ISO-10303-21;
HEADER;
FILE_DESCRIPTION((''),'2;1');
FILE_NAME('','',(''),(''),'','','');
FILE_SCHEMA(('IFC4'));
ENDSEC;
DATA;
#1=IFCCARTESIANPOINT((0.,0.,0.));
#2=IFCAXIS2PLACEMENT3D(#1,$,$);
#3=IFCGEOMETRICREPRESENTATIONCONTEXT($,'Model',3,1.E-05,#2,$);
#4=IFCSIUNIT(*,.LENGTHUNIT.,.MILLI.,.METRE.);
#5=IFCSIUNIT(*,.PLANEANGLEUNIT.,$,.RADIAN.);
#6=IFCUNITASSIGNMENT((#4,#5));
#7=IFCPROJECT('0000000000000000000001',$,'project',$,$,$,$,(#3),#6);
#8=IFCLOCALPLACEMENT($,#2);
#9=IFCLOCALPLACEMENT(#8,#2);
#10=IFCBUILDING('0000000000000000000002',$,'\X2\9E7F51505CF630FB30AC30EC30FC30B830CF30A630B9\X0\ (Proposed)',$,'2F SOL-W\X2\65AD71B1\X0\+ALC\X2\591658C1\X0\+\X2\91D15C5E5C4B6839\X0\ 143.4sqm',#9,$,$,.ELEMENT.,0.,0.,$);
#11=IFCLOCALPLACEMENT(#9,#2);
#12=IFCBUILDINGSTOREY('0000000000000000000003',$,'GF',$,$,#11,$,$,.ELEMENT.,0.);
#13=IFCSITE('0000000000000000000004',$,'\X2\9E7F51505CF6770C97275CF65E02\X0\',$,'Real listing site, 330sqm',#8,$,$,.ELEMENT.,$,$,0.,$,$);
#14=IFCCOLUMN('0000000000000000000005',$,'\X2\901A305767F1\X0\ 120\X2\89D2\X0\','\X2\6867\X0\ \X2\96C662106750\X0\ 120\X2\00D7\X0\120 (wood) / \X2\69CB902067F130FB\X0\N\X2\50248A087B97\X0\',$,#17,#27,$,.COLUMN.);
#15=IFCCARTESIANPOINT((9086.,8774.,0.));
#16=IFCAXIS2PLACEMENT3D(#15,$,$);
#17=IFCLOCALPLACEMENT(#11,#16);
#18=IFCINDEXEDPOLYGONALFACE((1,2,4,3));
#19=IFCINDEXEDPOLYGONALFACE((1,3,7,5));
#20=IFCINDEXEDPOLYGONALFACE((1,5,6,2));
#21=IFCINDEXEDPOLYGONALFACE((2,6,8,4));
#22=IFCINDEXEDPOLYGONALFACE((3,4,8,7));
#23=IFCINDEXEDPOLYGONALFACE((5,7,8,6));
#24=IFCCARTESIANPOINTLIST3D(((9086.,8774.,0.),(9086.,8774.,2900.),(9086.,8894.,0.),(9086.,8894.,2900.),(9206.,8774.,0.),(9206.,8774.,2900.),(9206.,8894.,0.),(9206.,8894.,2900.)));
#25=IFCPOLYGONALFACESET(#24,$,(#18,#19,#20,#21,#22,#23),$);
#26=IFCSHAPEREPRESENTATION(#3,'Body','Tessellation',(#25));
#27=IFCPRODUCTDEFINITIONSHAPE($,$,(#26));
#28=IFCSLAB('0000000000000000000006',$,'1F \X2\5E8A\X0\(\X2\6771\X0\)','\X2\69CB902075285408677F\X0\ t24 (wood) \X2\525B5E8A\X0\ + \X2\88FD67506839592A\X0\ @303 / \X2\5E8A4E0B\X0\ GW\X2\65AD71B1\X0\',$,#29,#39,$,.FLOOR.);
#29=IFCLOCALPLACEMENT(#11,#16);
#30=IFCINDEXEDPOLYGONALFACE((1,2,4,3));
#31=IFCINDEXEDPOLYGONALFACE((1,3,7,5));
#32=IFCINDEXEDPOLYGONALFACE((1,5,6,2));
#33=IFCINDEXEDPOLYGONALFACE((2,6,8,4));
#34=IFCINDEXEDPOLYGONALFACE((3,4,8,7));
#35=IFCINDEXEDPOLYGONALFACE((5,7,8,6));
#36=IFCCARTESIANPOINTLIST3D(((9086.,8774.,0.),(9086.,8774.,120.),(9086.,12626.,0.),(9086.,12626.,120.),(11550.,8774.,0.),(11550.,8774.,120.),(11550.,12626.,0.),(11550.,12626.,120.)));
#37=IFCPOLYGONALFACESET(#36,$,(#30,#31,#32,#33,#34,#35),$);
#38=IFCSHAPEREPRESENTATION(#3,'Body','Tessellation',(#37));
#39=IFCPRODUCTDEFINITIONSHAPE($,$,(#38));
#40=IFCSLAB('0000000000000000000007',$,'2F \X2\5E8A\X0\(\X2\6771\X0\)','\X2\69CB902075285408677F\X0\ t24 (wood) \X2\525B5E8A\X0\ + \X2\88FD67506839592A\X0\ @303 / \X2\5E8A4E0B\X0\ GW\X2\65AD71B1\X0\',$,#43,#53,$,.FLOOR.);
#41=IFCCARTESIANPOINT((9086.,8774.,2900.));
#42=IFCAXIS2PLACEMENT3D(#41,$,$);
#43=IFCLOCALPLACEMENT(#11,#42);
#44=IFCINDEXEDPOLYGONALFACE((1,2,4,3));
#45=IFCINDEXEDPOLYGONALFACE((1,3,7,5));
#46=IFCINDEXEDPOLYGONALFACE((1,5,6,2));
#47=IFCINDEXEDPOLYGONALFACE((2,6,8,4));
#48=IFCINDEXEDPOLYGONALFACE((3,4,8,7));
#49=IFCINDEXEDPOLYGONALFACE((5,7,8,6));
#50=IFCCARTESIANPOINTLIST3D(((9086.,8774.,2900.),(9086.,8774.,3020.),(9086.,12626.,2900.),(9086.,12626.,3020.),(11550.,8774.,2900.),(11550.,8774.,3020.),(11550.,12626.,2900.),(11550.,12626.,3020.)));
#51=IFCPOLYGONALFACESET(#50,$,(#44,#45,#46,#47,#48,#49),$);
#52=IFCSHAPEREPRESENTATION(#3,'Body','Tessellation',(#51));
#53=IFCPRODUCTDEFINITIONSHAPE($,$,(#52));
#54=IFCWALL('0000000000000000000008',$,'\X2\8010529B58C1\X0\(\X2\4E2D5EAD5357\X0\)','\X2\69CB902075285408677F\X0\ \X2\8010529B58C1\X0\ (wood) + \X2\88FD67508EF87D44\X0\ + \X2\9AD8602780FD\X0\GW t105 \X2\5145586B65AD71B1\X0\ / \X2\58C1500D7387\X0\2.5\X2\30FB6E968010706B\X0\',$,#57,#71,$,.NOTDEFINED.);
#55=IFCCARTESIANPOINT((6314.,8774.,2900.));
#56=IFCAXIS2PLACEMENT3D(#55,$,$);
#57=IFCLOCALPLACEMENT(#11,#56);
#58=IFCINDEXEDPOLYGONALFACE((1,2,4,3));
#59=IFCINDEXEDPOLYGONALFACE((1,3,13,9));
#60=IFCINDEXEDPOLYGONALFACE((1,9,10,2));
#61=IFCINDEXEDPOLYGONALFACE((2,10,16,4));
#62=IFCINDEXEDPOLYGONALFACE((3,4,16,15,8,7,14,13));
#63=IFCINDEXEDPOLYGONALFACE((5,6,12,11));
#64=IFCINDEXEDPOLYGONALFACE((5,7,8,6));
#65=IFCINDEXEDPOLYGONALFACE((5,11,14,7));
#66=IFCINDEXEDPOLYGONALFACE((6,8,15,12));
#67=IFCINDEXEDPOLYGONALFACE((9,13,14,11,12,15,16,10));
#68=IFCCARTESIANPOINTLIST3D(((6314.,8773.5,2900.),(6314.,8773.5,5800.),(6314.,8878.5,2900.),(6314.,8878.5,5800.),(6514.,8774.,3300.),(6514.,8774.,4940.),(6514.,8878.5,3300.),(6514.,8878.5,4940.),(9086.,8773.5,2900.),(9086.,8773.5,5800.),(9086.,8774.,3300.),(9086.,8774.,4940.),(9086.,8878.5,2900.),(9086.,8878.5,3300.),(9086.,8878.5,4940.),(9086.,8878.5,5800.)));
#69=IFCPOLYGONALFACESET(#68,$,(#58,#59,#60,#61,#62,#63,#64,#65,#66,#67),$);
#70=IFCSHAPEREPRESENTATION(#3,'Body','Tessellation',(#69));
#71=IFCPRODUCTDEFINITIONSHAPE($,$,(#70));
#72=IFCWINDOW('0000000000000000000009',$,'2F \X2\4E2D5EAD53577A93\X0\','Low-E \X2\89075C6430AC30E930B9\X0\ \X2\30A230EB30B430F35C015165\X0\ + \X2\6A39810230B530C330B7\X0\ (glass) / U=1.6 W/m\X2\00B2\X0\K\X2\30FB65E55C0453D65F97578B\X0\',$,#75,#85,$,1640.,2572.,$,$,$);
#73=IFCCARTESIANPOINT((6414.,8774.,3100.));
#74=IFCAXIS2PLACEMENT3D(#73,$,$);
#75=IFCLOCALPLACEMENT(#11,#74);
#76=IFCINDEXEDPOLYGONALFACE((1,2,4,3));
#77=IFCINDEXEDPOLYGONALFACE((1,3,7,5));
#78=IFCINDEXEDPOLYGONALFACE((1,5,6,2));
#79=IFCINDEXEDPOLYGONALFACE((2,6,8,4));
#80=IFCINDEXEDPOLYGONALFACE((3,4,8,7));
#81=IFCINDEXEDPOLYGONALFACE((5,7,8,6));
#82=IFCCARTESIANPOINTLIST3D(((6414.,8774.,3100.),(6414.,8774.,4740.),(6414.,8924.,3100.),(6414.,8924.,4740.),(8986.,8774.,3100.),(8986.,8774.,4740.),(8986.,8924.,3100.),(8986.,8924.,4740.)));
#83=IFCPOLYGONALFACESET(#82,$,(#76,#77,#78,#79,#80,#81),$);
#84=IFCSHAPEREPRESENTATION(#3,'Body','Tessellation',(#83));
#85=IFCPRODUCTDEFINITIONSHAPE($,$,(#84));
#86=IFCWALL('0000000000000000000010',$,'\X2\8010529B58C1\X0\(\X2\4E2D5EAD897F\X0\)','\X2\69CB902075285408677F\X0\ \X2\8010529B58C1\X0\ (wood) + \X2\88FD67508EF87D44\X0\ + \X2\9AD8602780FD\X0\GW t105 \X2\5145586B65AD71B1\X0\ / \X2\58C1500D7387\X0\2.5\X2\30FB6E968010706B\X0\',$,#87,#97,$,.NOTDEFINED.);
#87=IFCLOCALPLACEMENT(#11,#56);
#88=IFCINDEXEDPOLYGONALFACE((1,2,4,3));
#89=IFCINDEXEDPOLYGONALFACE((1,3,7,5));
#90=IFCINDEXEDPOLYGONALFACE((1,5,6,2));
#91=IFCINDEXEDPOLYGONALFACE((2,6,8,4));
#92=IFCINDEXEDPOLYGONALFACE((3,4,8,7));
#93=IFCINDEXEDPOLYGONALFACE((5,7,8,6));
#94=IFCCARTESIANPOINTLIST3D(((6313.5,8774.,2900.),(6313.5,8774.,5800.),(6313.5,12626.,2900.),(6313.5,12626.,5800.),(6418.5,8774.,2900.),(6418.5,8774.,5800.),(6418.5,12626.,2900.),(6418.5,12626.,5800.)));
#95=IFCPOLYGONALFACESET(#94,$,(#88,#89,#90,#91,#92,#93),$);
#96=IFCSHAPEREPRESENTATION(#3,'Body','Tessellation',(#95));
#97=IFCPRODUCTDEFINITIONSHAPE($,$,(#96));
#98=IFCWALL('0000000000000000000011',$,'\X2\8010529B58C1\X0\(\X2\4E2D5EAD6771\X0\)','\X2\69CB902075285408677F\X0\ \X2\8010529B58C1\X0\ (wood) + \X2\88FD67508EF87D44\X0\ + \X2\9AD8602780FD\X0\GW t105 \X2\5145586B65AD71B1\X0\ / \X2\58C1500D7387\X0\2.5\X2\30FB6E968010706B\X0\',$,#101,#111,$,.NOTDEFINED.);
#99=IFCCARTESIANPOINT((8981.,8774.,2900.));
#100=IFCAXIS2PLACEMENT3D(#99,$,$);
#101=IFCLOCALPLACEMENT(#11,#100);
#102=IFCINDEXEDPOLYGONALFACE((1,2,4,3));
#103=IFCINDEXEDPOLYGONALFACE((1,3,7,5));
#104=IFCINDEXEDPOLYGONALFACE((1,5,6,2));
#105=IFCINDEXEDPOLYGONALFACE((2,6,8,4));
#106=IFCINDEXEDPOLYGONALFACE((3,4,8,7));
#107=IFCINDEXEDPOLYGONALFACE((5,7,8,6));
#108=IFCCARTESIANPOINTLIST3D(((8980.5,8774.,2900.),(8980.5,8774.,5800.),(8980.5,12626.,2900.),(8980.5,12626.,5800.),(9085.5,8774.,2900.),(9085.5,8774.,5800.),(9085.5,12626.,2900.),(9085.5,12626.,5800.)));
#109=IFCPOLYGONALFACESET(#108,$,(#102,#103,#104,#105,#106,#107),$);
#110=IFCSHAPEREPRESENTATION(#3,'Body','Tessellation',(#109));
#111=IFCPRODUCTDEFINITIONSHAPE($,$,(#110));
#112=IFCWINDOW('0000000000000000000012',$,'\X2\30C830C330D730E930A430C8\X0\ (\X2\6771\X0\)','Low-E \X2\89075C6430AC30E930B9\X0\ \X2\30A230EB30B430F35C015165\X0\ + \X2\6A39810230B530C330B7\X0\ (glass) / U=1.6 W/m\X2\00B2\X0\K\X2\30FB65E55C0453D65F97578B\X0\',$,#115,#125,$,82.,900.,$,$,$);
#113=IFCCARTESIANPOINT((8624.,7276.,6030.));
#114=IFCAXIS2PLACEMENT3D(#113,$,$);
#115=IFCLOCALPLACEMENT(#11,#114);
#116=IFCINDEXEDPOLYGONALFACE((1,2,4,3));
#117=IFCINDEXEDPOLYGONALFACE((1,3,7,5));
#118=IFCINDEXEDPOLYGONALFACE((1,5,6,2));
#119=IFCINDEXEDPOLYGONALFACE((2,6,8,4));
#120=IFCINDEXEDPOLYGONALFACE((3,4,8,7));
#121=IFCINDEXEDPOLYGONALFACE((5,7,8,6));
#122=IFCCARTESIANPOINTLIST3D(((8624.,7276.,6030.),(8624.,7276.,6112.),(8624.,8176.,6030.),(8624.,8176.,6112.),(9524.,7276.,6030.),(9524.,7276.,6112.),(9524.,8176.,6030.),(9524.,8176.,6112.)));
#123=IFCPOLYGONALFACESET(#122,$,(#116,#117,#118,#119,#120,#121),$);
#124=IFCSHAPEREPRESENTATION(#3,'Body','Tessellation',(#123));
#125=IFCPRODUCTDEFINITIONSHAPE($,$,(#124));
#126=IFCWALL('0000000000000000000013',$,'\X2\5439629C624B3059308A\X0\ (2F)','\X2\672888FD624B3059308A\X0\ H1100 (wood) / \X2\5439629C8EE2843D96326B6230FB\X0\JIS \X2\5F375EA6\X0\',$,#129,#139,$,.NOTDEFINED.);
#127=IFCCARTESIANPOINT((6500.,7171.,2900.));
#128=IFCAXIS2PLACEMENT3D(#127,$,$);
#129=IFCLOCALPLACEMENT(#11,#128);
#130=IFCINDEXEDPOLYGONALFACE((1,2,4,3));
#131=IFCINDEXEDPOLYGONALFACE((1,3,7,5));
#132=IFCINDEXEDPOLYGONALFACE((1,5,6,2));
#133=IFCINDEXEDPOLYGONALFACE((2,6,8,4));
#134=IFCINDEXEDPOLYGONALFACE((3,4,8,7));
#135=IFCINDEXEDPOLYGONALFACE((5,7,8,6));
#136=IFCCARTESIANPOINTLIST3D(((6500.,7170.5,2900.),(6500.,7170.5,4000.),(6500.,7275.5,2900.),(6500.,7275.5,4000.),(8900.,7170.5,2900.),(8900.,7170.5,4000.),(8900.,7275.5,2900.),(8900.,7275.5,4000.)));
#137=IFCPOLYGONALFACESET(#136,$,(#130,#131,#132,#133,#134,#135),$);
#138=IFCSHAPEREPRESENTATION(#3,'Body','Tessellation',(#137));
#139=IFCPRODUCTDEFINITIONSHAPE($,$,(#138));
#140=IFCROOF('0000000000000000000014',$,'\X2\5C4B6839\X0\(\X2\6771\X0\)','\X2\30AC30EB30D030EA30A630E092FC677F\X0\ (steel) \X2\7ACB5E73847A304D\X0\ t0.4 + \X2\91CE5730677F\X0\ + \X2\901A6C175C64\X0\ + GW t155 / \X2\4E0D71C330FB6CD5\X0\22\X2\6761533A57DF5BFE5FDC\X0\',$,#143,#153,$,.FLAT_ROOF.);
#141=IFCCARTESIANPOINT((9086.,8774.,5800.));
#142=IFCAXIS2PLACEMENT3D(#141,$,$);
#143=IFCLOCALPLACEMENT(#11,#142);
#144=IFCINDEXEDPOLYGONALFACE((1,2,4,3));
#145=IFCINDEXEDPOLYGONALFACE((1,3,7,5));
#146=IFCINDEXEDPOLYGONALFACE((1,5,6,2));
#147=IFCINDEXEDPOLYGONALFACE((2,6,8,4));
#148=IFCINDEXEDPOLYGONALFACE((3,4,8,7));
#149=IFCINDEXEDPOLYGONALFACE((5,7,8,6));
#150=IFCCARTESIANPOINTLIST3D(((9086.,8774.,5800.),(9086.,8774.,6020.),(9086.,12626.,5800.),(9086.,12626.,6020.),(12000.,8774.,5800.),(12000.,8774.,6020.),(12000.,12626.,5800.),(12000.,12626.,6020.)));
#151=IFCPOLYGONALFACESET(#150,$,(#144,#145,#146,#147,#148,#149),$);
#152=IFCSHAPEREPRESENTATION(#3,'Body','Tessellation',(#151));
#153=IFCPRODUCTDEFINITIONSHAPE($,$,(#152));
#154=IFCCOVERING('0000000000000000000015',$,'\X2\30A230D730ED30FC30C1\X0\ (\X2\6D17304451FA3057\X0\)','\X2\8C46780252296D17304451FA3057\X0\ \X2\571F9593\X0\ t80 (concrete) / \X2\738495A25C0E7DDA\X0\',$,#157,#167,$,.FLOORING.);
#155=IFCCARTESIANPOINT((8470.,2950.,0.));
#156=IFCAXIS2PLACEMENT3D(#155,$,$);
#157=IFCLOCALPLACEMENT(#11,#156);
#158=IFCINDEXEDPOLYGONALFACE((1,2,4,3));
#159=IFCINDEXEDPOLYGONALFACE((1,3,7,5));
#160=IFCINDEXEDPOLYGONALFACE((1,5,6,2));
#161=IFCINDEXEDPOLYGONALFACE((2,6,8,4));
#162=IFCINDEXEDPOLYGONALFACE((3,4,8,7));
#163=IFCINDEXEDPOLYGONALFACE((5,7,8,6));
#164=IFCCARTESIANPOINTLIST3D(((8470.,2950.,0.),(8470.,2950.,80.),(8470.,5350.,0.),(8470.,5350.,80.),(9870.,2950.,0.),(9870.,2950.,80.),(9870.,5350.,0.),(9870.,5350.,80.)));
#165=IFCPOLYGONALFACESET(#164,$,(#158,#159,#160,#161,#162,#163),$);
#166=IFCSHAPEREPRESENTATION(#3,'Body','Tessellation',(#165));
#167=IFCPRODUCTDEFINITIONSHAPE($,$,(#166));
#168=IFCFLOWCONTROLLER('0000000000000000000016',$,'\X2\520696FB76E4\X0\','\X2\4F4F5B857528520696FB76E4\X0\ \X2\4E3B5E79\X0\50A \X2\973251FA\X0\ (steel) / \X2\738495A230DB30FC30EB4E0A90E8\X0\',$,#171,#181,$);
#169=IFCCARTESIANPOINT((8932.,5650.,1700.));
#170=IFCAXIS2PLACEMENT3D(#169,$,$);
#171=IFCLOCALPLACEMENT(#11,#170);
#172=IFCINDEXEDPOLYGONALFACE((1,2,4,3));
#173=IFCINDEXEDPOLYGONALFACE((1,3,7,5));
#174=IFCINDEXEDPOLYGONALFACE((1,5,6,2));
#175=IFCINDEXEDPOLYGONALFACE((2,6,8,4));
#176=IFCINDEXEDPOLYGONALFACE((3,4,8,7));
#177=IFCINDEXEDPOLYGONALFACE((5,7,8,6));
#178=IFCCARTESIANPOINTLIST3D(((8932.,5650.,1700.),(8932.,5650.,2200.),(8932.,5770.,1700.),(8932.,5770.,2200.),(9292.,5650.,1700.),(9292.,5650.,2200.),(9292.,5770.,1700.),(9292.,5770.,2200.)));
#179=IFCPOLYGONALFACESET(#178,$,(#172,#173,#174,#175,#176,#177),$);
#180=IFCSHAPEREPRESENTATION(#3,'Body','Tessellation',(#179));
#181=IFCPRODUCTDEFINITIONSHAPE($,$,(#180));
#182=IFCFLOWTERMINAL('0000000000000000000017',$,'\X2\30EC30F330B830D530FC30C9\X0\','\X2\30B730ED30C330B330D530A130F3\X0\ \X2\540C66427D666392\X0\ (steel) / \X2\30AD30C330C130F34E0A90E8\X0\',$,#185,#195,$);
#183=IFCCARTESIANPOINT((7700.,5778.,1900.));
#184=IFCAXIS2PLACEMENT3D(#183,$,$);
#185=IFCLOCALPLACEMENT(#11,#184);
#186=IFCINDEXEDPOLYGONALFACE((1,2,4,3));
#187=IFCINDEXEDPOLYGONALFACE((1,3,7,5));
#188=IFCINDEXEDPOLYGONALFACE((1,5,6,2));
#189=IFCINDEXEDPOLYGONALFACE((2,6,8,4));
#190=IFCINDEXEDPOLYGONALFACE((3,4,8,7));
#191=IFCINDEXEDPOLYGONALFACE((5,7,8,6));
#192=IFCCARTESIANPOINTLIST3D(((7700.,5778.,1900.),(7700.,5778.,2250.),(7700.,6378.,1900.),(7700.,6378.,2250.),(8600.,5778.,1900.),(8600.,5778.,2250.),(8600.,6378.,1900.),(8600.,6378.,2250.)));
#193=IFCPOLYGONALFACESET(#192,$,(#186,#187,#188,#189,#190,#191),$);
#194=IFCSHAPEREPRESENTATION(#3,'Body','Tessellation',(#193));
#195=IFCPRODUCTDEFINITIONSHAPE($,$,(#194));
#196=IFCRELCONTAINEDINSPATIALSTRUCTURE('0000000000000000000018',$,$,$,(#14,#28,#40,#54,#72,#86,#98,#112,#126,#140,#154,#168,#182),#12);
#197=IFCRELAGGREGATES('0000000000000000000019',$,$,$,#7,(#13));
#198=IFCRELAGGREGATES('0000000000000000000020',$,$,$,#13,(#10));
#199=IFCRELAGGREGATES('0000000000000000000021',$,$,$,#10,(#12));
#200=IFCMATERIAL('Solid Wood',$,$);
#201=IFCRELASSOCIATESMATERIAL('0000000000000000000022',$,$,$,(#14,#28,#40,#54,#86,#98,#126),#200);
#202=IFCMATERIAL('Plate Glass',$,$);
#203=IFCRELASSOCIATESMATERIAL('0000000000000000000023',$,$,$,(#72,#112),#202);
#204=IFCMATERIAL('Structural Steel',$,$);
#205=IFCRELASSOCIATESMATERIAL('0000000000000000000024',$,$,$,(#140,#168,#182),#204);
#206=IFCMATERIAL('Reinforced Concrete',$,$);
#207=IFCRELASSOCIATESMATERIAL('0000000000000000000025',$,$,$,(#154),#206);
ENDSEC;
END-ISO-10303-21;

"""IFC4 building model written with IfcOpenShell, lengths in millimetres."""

from ifc_helpers import new_model, si_unit, frame, frame_2d, origin, place, context, project, spatial, rectangle, extrude, material, element, fill, save


model = new_model("IFC4")

# Units and contexts
model_context = context("Model", 3, precision=1e-05, world=origin())
ifc_project = project(units=[si_unit("LENGTHUNIT", "METRE", prefix="MILLI"), si_unit("PLANEANGLEUNIT", "RADIAN")], contexts=[model_context])

# Site, building, storey
site_placement = place(None, origin())
site = spatial("IfcSite", under=ifc_project, at=site_placement, Name="鹿児島県霧島市", ObjectType="Real listing site, 330sqm", CompositionType="ELEMENT", RefElevation=0.0)
building_placement = place(site_placement, origin())
building = spatial("IfcBuilding", under=site, at=building_placement, Name="鹿児島・ガレージハウス (Proposed)", ObjectType="2F SOL-W断熱+ALC外壁+金属屋根 143.4sqm", CompositionType="ELEMENT", ElevationOfRefHeight=0.0, ElevationOfTerrain=0.0)
storey_placement = place(building_placement, origin())
storey = spatial("IfcBuildingStorey", under=building, at=storey_placement, Name="GF", CompositionType="ELEMENT", Elevation=0.0)

# Column
ifc_material_1 = material(Name="Solid Wood")
column_1_placement = place(storey_placement, frame((9086.0, 8774.0, 0.0)))
element("IfcColumn", 1, at=column_1_placement, inside=storey, material=ifc_material_1, Name="通し柱 120角", Description="桧 集成材 120×120 (wood) / 構造柱・N値計算", PredefinedType="COLUMN", context=model_context, shape_type="SweptSolid", body=[
    extrude(rectangle(XDim=120.0, YDim=120.0, at=frame_2d((60.0, 60.0))), frame((9086.0, 8774.0, 0.0)), (0.0, 0.0, 1.0), 2900.0),
])

# Slabs
slab_1_placement = place(storey_placement, frame((9086.0, 8774.0, 0.0)))
element("IfcSlab", 2, at=slab_1_placement, inside=storey, material=ifc_material_1, Name="1F 床(東)", Description="構造用合板 t24 (wood) 剛床 + 製材根太 @303 / 床下 GW断熱", PredefinedType="FLOOR", context=model_context, shape_type="SweptSolid", body=[
    extrude(rectangle(XDim=2464.0, YDim=3852.0, at=frame_2d((1232.0, 1926.0))), frame((9086.0, 8774.0, 0.0)), (0.0, 0.0, 1.0), 120.0),
])
slab_2_placement = place(storey_placement, frame((9086.0, 8774.0, 2900.0)))
element("IfcSlab", 3, at=slab_2_placement, inside=storey, material=ifc_material_1, Name="2F 床(東)", Description="構造用合板 t24 (wood) 剛床 + 製材根太 @303 / 床下 GW断熱", PredefinedType="FLOOR", context=model_context, shape_type="SweptSolid", body=[
    extrude(rectangle(XDim=2464.0, YDim=3852.0, at=frame_2d((1232.0, 1926.0))), frame((9086.0, 8774.0, 2900.0)), (0.0, 0.0, 1.0), 120.0),
])

# Wall, opening, window
wall_1_placement = place(storey_placement, frame((6314.0, 8774.0, 2900.0)))
wall_1 = element("IfcWall", 4, at=wall_1_placement, inside=storey, material=ifc_material_1, Name="耐力壁(中庭南)", Description="構造用合板 耐力壁 (wood) + 製材軸組 + 高性能GW t105 充填断熱 / 壁倍率2.5・準耐火", PredefinedType="NOTDEFINED", context=model_context, shape_type="SweptSolid", body=[
    extrude(rectangle(XDim=2772.0, YDim=105.0, at=frame_2d((1386.0, 52.0))), frame((6314.0, 8774.0, 2900.0)), (0.0, 0.0, 1.0), 2900.0),
])
opening_placement = place(storey_placement, frame((6414.0, 8774.0, 3100.0)))
opening = element("IfcOpeningElement", 5, at=opening_placement, cuts=wall_1, PredefinedType="NOTDEFINED", context=model_context, shape_type="SweptSolid", body=[
    extrude(rectangle(XDim=2572.0, YDim=150.0, at=frame_2d((1286.0, 75.0))), frame((6414.0, 8774.0, 3100.0)), (0.0, 0.0, 1.0), 1640.0),
])
ifc_material_2 = material(Name="Plate Glass")
window_1_placement = place(storey_placement, frame((6414.0, 8774.0, 3100.0)))
window_1 = element("IfcWindow", 6, at=window_1_placement, inside=storey, material=ifc_material_2, Name="2F 中庭南窓", Description="Low-E 複層ガラス アルゴン封入 + 樹脂サッシ (glass) / U=1.6 W/m²K・日射取得型", OverallHeight=1640.0, OverallWidth=2572.0, context=model_context, shape_type="SweptSolid", body=[
    extrude(rectangle(XDim=2572.0, YDim=150.0, at=frame_2d((1286.0, 75.0))), frame((6414.0, 8774.0, 3100.0)), (0.0, 0.0, 1.0), 1640.0),
])
fill(opening, window_1)

# Walls
wall_2_placement = place(storey_placement, frame((6314.0, 8774.0, 2900.0)))
element("IfcWall", 7, at=wall_2_placement, inside=storey, material=ifc_material_1, Name="耐力壁(中庭西)", Description="構造用合板 耐力壁 (wood) + 製材軸組 + 高性能GW t105 充填断熱 / 壁倍率2.5・準耐火", PredefinedType="NOTDEFINED", context=model_context, shape_type="SweptSolid", body=[
    extrude(rectangle(XDim=105.0, YDim=3852.0, at=frame_2d((52.0, 1926.0))), frame((6314.0, 8774.0, 2900.0)), (0.0, 0.0, 1.0), 2900.0),
])
wall_3_placement = place(storey_placement, frame((8981.0, 8774.0, 2900.0)))
element("IfcWall", 8, at=wall_3_placement, inside=storey, material=ifc_material_1, Name="耐力壁(中庭東)", Description="構造用合板 耐力壁 (wood) + 製材軸組 + 高性能GW t105 充填断熱 / 壁倍率2.5・準耐火", PredefinedType="NOTDEFINED", context=model_context, shape_type="SweptSolid", body=[
    extrude(rectangle(XDim=105.0, YDim=3852.0, at=frame_2d((52.0, 1926.0))), frame((8981.0, 8774.0, 2900.0)), (0.0, 0.0, 1.0), 2900.0),
])

# Window
window_2_placement = place(storey_placement, frame((8624.0, 7276.0, 6030.0)))
element("IfcWindow", 9, at=window_2_placement, inside=storey, material=ifc_material_2, Name="トップライト (東)", Description="Low-E 複層ガラス アルゴン封入 + 樹脂サッシ (glass) / U=1.6 W/m²K・日射取得型", OverallHeight=82.0, OverallWidth=900.0, context=model_context, shape_type="SweptSolid", body=[
    extrude(rectangle(XDim=900.0, YDim=900.0, at=frame_2d((450.0, 450.0))), frame((8624.0, 7276.0, 6030.0)), (0.0, 0.0, 1.0), 82.0),
])

# Wall
wall_4_placement = place(storey_placement, frame((6500.0, 7171.0, 2900.0)))
element("IfcWall", 10, at=wall_4_placement, inside=storey, material=ifc_material_1, Name="吹抜手すり (2F)", Description="木製手すり H1100 (wood) / 吹抜転落防止・JIS 強度", PredefinedType="NOTDEFINED", context=model_context, shape_type="SweptSolid", body=[
    extrude(rectangle(XDim=2400.0, YDim=105.0, at=frame_2d((1200.0, 52.0))), frame((6500.0, 7171.0, 2900.0)), (0.0, 0.0, 1.0), 1100.0),
])

# Roof
ifc_material_3 = material(Name="Structural Steel")
for number, where, name in (
    (11, (9086.0, 8774.0, 5800.0), "屋根(東)"),
):
    element("IfcRoof", number, at=place(storey_placement, frame(where)), inside=storey, material=ifc_material_3, Name=name, Description="ガルバリウム鋼板 (steel) 立平葺き t0.4 + 野地板 + 通気層 + GW t155 / 不燃・法22条区域対応", PredefinedType="FLAT_ROOF", context=model_context, shape_type="SweptSolid", body=[
        extrude(rectangle(XDim=2914.0, YDim=3852.0, at=frame_2d((1457.0, 1926.0))), frame((9086.0, 8774.0, 5800.0)), (0.0, 0.0, 1.0), 220.0),
    ])

# Covering
ifc_material_4 = material(Name="Reinforced Concrete")
covering_placement = place(storey_placement, frame((8470.0, 2950.0, 0.0)))
element("IfcCovering", 12, at=covering_placement, inside=storey, material=ifc_material_4, Name="アプローチ (洗い出し)", Description="豆砂利洗い出し 土間 t80 (concrete) / 玄関導線", PredefinedType="FLOORING", context=model_context, shape_type="SweptSolid", body=[
    extrude(rectangle(XDim=1400.0, YDim=2400.0, at=frame_2d((700.0, 1200.0))), frame((8470.0, 2950.0, 0.0)), (0.0, 0.0, 1.0), 80.0),
])

# Flow controller
flow_controller_placement = place(storey_placement, frame((8932.0, 5650.0, 1700.0)))
element("IfcFlowController", 13, at=flow_controller_placement, inside=storey, material=ifc_material_3, Name="分電盤", Description="住宅用分電盤 主幹50A 露出 (steel) / 玄関ホール上部", context=model_context, shape_type="SweptSolid", body=[
    extrude(rectangle(XDim=360.0, YDim=120.0, at=frame_2d((180.0, 60.0))), frame((8932.0, 5650.0, 1700.0)), (0.0, 0.0, 1.0), 500.0),
])

# Flow terminal
flow_terminal_1_placement = place(storey_placement, frame((7700.0, 5778.0, 1900.0)))
element("IfcFlowTerminal", 14, at=flow_terminal_1_placement, inside=storey, material=ifc_material_3, Name="レンジフード", Description="シロッコファン 同時給排 (steel) / キッチン上部", context=model_context, shape_type="SweptSolid", body=[
    extrude(rectangle(XDim=900.0, YDim=600.0, at=frame_2d((450.0, 300.0))), frame((7700.0, 5778.0, 1900.0)), (0.0, 0.0, 1.0), 350.0),
])

save(model, "model.ifc")
